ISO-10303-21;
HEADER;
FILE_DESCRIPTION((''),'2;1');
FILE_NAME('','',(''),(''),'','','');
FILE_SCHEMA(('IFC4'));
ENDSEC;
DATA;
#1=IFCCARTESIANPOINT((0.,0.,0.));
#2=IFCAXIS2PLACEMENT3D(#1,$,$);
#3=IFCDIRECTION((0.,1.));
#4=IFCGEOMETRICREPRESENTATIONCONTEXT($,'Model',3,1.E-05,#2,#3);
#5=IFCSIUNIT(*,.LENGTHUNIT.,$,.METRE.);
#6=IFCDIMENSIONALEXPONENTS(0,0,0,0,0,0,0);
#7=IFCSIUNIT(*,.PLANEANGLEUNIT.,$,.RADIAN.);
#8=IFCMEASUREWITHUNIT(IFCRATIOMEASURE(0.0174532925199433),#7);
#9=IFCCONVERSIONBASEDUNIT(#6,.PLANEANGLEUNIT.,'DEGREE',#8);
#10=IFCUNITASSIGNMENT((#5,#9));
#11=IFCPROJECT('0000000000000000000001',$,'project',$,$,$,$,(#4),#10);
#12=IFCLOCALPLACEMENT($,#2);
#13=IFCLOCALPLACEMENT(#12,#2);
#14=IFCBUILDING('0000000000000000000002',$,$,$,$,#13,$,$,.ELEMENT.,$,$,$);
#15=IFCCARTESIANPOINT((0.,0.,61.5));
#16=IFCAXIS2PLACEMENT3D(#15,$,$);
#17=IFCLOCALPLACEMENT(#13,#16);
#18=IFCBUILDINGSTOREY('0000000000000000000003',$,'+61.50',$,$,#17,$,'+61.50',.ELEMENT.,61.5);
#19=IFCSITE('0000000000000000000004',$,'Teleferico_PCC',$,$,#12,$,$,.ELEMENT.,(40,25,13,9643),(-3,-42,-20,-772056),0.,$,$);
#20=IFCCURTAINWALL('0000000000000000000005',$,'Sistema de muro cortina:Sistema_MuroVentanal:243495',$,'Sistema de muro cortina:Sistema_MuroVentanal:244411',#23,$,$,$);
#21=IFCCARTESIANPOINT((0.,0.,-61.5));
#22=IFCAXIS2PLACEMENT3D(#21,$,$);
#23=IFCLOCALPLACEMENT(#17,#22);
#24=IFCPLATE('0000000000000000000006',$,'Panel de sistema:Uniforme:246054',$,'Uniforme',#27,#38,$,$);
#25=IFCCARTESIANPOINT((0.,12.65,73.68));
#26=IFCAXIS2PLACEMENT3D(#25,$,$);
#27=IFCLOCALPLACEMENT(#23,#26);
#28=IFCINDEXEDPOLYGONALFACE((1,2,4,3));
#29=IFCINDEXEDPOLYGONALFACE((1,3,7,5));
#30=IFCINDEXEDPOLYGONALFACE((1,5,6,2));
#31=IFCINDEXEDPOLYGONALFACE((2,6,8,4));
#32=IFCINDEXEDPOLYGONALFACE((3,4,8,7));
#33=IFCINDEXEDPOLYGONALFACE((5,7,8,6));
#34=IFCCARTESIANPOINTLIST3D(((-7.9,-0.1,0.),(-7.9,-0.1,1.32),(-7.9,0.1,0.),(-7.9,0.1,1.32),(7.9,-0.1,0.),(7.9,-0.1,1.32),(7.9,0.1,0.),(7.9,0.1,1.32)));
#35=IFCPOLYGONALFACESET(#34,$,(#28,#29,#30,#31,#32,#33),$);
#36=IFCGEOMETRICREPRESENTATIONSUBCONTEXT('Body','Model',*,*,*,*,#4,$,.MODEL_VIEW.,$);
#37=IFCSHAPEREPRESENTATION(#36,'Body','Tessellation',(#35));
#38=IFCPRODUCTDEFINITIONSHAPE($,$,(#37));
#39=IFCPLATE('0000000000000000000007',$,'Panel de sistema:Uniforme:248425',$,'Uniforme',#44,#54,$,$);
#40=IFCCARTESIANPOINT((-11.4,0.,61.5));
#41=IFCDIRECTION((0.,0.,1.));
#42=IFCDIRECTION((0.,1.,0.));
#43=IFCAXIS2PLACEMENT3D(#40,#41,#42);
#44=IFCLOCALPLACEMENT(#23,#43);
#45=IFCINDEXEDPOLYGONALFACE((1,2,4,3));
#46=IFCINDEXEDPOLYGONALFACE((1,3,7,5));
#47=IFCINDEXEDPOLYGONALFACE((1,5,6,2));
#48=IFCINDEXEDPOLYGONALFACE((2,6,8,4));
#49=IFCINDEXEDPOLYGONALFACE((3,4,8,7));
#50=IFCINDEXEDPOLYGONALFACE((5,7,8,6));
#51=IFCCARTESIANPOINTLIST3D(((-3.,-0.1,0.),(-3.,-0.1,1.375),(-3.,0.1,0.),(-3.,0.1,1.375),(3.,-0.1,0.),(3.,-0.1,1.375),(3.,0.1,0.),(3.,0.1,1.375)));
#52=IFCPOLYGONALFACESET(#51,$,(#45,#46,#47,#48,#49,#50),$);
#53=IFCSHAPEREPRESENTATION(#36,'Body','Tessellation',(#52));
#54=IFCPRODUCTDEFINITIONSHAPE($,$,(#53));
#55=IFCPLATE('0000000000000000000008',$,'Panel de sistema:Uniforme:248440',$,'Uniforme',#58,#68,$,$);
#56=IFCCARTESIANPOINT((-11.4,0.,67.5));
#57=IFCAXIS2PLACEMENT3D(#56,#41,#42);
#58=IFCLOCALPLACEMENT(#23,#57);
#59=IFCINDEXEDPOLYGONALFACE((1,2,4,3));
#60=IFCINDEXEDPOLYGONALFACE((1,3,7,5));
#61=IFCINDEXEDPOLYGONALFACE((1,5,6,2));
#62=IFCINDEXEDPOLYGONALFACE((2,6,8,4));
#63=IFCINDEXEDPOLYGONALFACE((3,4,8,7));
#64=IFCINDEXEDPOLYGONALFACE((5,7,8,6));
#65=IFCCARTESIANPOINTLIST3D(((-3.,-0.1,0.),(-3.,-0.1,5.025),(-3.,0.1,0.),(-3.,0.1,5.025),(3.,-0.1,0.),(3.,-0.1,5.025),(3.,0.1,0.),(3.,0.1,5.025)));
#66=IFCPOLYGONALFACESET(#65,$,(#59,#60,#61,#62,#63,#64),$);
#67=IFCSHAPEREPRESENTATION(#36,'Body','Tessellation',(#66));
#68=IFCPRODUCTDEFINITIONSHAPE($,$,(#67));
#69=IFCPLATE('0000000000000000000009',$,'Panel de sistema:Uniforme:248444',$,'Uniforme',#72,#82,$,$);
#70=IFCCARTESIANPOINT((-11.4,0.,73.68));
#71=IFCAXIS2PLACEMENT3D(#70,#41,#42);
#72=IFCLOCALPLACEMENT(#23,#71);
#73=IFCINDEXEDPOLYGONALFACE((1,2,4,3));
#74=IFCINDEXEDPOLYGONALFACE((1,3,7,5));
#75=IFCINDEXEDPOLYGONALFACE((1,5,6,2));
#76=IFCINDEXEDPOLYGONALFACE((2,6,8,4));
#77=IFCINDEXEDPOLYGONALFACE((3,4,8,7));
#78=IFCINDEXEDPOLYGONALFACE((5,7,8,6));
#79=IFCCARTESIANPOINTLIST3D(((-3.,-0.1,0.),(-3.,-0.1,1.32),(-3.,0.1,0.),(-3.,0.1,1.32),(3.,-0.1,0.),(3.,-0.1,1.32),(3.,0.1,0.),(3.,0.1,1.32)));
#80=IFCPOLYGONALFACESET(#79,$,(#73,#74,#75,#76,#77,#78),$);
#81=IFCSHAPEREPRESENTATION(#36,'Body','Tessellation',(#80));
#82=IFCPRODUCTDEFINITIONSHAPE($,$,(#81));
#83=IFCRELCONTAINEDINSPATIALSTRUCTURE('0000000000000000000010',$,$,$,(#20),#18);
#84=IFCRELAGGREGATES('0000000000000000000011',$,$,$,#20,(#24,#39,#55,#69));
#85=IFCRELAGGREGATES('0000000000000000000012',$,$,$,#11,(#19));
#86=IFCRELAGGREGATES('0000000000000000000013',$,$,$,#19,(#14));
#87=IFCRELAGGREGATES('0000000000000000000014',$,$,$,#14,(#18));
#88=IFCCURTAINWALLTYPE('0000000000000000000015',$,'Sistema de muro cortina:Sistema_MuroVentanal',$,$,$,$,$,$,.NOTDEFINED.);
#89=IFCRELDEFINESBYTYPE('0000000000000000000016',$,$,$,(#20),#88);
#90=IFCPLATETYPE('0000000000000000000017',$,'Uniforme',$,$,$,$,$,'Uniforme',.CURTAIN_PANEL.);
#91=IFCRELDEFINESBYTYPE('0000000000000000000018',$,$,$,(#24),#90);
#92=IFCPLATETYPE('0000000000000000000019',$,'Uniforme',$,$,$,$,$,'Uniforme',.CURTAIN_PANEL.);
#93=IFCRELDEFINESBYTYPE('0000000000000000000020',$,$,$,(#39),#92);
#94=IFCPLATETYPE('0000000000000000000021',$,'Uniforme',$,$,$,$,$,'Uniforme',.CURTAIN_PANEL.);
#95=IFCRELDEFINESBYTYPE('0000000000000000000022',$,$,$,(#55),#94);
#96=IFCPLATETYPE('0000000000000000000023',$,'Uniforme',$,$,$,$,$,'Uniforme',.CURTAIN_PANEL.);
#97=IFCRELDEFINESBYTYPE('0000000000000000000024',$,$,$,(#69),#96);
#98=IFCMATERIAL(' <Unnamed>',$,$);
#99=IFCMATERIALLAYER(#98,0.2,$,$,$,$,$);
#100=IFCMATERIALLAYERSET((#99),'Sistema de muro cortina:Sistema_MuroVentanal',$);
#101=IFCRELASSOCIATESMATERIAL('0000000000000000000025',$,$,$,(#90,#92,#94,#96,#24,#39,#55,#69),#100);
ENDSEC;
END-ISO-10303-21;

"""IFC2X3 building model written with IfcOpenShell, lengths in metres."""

from ifc_helpers import new_model, entity, si_unit, converted_unit, direction, frame, origin, origin_2d_with_axis, place, context, subcontext, project, spatial, rectangle, extrude, source, transform, mapped, material, layer, layer_set, layer_usage, type_object, type_shapes, element, aggregate, save


model = new_model("IFC2X3")

# Units and contexts
model_context = context("Model", 3, precision=1e-05, world=origin(), true_north=direction((0.0, 1.0)))
body_context = subcontext(model_context, "Body", "Model", "MODEL_VIEW")
ifc_project = project(units=[si_unit("LENGTHUNIT", "METRE"), converted_unit("PLANEANGLEUNIT", "DEGREE", entity("IfcRatioMeasure", 0.0174532925199433), si_unit("PLANEANGLEUNIT", "RADIAN"), dimensions=[0, 0, 0, 0, 0, 0, 0])], contexts=[model_context])

# Site, building, storey
site_placement = place(None, origin())
site = spatial("IfcSite", under=ifc_project, at=site_placement, Name="Teleferico_PCC", CompositionType="ELEMENT", RefLatitude=(40, 25, 13, 9643), RefLongitude=(-3, -42, -20, -772056), RefElevation=0.0)
building_placement = place(site_placement, origin())
building = spatial("IfcBuilding", under=site, at=building_placement, CompositionType="ELEMENT")
storey_placement = place(building_placement, frame((0.0, 0.0, 61.5)))
storey = spatial("IfcBuildingStorey", under=building, at=storey_placement, Name="+61.50", LongName="+61.50", CompositionType="ELEMENT", Elevation=61.5)

# Curtain wall, plates
curtain_wall_type = type_object("IfcCurtainWallType", Name="Sistema de muro cortina:Sistema_MuroVentanal", PredefinedType="NOTDEFINED")
curtain_wall_placement = place(storey_placement, frame((0.0, 0.0, -61.5)))
curtain_wall = element("IfcCurtainWall", 1, at=curtain_wall_placement, inside=storey, type_object=curtain_wall_type, Name="Sistema de muro cortina:Sistema_MuroVentanal:243495", ObjectType="Sistema de muro cortina:Sistema_MuroVentanal:244411")
ifc_material_1 = material(Name=" <Unnamed>")
ifc_layer_1 = layer(ifc_material_1, 0.2)
ifc_layer_set_1 = layer_set([ifc_layer_1], Name="Sistema de muro cortina:Sistema_MuroVentanal")
ifc_layer_usage_1 = layer_usage(ifc_layer_set_1, "AXIS3", "POSITIVE", 0.0)
plate_type_1 = type_object("IfcPlateType", Name="Uniforme", ElementType="Uniforme", PredefinedType="CURTAIN_PANEL", material=ifc_layer_set_1)
shared_shape_1 = source(origin(), body_context, "Body", "SweptSolid", [
    extrude(rectangle(XDim=0.2, YDim=15.8, at=origin_2d_with_axis()), frame((0.0, 0.0, 0.0), z_axis=(0.0, 0.0, 1.0), x_axis=(0.0, 1.0, 0.0)), (0.0, 0.0, 1.0), 1.32),
])
type_shapes(plate_type_1, [shared_shape_1])
plate_1_placement = place(curtain_wall_placement, frame((0.0, 12.65, 73.68)))
plate_1 = element("IfcPlate", 2, at=plate_1_placement, type_object=plate_type_1, material=ifc_layer_usage_1, Name="Panel de sistema:Uniforme:246054", ObjectType="Uniforme", context=body_context, shape_type="MappedRepresentation", body=[
    mapped(shared_shape_1, transform((0.0, 0.0, 0.0), scale=1.0)),
])
ifc_layer_usage_2 = layer_usage(ifc_layer_set_1, "AXIS3", "POSITIVE", 0.0)
plate_type_2 = type_object("IfcPlateType", Name="Uniforme", ElementType="Uniforme", PredefinedType="CURTAIN_PANEL", material=ifc_layer_set_1)
shared_shape_2 = source(origin(), body_context, "Body", "SweptSolid", [
    extrude(rectangle(XDim=0.2, YDim=6.0, at=origin_2d_with_axis()), frame((0.0, 0.0, 0.0), z_axis=(0.0, 0.0, 1.0), x_axis=(0.0, 1.0, 0.0)), (0.0, 0.0, 1.0), 1.375),
])
type_shapes(plate_type_2, [shared_shape_2])
plate_2_placement = place(curtain_wall_placement, frame((-11.4, 0.0, 61.5), z_axis=(0.0, 0.0, 1.0), x_axis=(0.0, 1.0, 0.0)))
plate_2 = element("IfcPlate", 3, at=plate_2_placement, type_object=plate_type_2, material=ifc_layer_usage_2, Name="Panel de sistema:Uniforme:248425", ObjectType="Uniforme", context=body_context, shape_type="MappedRepresentation", body=[
    mapped(shared_shape_2, transform((0.0, 0.0, 0.0), scale=1.0)),
])
ifc_layer_usage_3 = layer_usage(ifc_layer_set_1, "AXIS3", "POSITIVE", 0.0)
plate_type_3 = type_object("IfcPlateType", Name="Uniforme", ElementType="Uniforme", PredefinedType="CURTAIN_PANEL", material=ifc_layer_set_1)
shared_shape_3 = source(origin(), body_context, "Body", "SweptSolid", [
    extrude(rectangle(XDim=0.2, YDim=6.0, at=origin_2d_with_axis()), frame((0.0, 0.0, 0.0), z_axis=(0.0, 0.0, 1.0), x_axis=(0.0, 1.0, 0.0)), (0.0, 0.0, 1.0), 5.025),
])
type_shapes(plate_type_3, [shared_shape_3])
plate_3_placement = place(curtain_wall_placement, frame((-11.4, 0.0, 67.5), z_axis=(0.0, 0.0, 1.0), x_axis=(0.0, 1.0, 0.0)))
plate_3 = element("IfcPlate", 4, at=plate_3_placement, type_object=plate_type_3, material=ifc_layer_usage_3, Name="Panel de sistema:Uniforme:248440", ObjectType="Uniforme", context=body_context, shape_type="MappedRepresentation", body=[
    mapped(shared_shape_3, transform((0.0, 0.0, 0.0), scale=1.0)),
])
ifc_layer_usage_4 = layer_usage(ifc_layer_set_1, "AXIS3", "POSITIVE", 0.0)
plate_type_4 = type_object("IfcPlateType", Name="Uniforme", ElementType="Uniforme", PredefinedType="CURTAIN_PANEL", material=ifc_layer_set_1)
shared_shape_4 = source(origin(), body_context, "Body", "SweptSolid", [
    extrude(rectangle(XDim=0.2, YDim=6.0, at=origin_2d_with_axis()), frame((0.0, 0.0, 0.0), z_axis=(0.0, 0.0, 1.0), x_axis=(0.0, 1.0, 0.0)), (0.0, 0.0, 1.0), 1.32),
])
type_shapes(plate_type_4, [shared_shape_4])
plate_4_placement = place(curtain_wall_placement, frame((-11.4, 0.0, 73.68), z_axis=(0.0, 0.0, 1.0), x_axis=(0.0, 1.0, 0.0)))
plate_4 = element("IfcPlate", 5, at=plate_4_placement, type_object=plate_type_4, material=ifc_layer_usage_4, Name="Panel de sistema:Uniforme:248444", ObjectType="Uniforme", context=body_context, shape_type="MappedRepresentation", body=[
    mapped(shared_shape_4, transform((0.0, 0.0, 0.0), scale=1.0)),
])
aggregate(curtain_wall, [plate_1, plate_2, plate_3, plate_4])

save(model, "model.ifc")
